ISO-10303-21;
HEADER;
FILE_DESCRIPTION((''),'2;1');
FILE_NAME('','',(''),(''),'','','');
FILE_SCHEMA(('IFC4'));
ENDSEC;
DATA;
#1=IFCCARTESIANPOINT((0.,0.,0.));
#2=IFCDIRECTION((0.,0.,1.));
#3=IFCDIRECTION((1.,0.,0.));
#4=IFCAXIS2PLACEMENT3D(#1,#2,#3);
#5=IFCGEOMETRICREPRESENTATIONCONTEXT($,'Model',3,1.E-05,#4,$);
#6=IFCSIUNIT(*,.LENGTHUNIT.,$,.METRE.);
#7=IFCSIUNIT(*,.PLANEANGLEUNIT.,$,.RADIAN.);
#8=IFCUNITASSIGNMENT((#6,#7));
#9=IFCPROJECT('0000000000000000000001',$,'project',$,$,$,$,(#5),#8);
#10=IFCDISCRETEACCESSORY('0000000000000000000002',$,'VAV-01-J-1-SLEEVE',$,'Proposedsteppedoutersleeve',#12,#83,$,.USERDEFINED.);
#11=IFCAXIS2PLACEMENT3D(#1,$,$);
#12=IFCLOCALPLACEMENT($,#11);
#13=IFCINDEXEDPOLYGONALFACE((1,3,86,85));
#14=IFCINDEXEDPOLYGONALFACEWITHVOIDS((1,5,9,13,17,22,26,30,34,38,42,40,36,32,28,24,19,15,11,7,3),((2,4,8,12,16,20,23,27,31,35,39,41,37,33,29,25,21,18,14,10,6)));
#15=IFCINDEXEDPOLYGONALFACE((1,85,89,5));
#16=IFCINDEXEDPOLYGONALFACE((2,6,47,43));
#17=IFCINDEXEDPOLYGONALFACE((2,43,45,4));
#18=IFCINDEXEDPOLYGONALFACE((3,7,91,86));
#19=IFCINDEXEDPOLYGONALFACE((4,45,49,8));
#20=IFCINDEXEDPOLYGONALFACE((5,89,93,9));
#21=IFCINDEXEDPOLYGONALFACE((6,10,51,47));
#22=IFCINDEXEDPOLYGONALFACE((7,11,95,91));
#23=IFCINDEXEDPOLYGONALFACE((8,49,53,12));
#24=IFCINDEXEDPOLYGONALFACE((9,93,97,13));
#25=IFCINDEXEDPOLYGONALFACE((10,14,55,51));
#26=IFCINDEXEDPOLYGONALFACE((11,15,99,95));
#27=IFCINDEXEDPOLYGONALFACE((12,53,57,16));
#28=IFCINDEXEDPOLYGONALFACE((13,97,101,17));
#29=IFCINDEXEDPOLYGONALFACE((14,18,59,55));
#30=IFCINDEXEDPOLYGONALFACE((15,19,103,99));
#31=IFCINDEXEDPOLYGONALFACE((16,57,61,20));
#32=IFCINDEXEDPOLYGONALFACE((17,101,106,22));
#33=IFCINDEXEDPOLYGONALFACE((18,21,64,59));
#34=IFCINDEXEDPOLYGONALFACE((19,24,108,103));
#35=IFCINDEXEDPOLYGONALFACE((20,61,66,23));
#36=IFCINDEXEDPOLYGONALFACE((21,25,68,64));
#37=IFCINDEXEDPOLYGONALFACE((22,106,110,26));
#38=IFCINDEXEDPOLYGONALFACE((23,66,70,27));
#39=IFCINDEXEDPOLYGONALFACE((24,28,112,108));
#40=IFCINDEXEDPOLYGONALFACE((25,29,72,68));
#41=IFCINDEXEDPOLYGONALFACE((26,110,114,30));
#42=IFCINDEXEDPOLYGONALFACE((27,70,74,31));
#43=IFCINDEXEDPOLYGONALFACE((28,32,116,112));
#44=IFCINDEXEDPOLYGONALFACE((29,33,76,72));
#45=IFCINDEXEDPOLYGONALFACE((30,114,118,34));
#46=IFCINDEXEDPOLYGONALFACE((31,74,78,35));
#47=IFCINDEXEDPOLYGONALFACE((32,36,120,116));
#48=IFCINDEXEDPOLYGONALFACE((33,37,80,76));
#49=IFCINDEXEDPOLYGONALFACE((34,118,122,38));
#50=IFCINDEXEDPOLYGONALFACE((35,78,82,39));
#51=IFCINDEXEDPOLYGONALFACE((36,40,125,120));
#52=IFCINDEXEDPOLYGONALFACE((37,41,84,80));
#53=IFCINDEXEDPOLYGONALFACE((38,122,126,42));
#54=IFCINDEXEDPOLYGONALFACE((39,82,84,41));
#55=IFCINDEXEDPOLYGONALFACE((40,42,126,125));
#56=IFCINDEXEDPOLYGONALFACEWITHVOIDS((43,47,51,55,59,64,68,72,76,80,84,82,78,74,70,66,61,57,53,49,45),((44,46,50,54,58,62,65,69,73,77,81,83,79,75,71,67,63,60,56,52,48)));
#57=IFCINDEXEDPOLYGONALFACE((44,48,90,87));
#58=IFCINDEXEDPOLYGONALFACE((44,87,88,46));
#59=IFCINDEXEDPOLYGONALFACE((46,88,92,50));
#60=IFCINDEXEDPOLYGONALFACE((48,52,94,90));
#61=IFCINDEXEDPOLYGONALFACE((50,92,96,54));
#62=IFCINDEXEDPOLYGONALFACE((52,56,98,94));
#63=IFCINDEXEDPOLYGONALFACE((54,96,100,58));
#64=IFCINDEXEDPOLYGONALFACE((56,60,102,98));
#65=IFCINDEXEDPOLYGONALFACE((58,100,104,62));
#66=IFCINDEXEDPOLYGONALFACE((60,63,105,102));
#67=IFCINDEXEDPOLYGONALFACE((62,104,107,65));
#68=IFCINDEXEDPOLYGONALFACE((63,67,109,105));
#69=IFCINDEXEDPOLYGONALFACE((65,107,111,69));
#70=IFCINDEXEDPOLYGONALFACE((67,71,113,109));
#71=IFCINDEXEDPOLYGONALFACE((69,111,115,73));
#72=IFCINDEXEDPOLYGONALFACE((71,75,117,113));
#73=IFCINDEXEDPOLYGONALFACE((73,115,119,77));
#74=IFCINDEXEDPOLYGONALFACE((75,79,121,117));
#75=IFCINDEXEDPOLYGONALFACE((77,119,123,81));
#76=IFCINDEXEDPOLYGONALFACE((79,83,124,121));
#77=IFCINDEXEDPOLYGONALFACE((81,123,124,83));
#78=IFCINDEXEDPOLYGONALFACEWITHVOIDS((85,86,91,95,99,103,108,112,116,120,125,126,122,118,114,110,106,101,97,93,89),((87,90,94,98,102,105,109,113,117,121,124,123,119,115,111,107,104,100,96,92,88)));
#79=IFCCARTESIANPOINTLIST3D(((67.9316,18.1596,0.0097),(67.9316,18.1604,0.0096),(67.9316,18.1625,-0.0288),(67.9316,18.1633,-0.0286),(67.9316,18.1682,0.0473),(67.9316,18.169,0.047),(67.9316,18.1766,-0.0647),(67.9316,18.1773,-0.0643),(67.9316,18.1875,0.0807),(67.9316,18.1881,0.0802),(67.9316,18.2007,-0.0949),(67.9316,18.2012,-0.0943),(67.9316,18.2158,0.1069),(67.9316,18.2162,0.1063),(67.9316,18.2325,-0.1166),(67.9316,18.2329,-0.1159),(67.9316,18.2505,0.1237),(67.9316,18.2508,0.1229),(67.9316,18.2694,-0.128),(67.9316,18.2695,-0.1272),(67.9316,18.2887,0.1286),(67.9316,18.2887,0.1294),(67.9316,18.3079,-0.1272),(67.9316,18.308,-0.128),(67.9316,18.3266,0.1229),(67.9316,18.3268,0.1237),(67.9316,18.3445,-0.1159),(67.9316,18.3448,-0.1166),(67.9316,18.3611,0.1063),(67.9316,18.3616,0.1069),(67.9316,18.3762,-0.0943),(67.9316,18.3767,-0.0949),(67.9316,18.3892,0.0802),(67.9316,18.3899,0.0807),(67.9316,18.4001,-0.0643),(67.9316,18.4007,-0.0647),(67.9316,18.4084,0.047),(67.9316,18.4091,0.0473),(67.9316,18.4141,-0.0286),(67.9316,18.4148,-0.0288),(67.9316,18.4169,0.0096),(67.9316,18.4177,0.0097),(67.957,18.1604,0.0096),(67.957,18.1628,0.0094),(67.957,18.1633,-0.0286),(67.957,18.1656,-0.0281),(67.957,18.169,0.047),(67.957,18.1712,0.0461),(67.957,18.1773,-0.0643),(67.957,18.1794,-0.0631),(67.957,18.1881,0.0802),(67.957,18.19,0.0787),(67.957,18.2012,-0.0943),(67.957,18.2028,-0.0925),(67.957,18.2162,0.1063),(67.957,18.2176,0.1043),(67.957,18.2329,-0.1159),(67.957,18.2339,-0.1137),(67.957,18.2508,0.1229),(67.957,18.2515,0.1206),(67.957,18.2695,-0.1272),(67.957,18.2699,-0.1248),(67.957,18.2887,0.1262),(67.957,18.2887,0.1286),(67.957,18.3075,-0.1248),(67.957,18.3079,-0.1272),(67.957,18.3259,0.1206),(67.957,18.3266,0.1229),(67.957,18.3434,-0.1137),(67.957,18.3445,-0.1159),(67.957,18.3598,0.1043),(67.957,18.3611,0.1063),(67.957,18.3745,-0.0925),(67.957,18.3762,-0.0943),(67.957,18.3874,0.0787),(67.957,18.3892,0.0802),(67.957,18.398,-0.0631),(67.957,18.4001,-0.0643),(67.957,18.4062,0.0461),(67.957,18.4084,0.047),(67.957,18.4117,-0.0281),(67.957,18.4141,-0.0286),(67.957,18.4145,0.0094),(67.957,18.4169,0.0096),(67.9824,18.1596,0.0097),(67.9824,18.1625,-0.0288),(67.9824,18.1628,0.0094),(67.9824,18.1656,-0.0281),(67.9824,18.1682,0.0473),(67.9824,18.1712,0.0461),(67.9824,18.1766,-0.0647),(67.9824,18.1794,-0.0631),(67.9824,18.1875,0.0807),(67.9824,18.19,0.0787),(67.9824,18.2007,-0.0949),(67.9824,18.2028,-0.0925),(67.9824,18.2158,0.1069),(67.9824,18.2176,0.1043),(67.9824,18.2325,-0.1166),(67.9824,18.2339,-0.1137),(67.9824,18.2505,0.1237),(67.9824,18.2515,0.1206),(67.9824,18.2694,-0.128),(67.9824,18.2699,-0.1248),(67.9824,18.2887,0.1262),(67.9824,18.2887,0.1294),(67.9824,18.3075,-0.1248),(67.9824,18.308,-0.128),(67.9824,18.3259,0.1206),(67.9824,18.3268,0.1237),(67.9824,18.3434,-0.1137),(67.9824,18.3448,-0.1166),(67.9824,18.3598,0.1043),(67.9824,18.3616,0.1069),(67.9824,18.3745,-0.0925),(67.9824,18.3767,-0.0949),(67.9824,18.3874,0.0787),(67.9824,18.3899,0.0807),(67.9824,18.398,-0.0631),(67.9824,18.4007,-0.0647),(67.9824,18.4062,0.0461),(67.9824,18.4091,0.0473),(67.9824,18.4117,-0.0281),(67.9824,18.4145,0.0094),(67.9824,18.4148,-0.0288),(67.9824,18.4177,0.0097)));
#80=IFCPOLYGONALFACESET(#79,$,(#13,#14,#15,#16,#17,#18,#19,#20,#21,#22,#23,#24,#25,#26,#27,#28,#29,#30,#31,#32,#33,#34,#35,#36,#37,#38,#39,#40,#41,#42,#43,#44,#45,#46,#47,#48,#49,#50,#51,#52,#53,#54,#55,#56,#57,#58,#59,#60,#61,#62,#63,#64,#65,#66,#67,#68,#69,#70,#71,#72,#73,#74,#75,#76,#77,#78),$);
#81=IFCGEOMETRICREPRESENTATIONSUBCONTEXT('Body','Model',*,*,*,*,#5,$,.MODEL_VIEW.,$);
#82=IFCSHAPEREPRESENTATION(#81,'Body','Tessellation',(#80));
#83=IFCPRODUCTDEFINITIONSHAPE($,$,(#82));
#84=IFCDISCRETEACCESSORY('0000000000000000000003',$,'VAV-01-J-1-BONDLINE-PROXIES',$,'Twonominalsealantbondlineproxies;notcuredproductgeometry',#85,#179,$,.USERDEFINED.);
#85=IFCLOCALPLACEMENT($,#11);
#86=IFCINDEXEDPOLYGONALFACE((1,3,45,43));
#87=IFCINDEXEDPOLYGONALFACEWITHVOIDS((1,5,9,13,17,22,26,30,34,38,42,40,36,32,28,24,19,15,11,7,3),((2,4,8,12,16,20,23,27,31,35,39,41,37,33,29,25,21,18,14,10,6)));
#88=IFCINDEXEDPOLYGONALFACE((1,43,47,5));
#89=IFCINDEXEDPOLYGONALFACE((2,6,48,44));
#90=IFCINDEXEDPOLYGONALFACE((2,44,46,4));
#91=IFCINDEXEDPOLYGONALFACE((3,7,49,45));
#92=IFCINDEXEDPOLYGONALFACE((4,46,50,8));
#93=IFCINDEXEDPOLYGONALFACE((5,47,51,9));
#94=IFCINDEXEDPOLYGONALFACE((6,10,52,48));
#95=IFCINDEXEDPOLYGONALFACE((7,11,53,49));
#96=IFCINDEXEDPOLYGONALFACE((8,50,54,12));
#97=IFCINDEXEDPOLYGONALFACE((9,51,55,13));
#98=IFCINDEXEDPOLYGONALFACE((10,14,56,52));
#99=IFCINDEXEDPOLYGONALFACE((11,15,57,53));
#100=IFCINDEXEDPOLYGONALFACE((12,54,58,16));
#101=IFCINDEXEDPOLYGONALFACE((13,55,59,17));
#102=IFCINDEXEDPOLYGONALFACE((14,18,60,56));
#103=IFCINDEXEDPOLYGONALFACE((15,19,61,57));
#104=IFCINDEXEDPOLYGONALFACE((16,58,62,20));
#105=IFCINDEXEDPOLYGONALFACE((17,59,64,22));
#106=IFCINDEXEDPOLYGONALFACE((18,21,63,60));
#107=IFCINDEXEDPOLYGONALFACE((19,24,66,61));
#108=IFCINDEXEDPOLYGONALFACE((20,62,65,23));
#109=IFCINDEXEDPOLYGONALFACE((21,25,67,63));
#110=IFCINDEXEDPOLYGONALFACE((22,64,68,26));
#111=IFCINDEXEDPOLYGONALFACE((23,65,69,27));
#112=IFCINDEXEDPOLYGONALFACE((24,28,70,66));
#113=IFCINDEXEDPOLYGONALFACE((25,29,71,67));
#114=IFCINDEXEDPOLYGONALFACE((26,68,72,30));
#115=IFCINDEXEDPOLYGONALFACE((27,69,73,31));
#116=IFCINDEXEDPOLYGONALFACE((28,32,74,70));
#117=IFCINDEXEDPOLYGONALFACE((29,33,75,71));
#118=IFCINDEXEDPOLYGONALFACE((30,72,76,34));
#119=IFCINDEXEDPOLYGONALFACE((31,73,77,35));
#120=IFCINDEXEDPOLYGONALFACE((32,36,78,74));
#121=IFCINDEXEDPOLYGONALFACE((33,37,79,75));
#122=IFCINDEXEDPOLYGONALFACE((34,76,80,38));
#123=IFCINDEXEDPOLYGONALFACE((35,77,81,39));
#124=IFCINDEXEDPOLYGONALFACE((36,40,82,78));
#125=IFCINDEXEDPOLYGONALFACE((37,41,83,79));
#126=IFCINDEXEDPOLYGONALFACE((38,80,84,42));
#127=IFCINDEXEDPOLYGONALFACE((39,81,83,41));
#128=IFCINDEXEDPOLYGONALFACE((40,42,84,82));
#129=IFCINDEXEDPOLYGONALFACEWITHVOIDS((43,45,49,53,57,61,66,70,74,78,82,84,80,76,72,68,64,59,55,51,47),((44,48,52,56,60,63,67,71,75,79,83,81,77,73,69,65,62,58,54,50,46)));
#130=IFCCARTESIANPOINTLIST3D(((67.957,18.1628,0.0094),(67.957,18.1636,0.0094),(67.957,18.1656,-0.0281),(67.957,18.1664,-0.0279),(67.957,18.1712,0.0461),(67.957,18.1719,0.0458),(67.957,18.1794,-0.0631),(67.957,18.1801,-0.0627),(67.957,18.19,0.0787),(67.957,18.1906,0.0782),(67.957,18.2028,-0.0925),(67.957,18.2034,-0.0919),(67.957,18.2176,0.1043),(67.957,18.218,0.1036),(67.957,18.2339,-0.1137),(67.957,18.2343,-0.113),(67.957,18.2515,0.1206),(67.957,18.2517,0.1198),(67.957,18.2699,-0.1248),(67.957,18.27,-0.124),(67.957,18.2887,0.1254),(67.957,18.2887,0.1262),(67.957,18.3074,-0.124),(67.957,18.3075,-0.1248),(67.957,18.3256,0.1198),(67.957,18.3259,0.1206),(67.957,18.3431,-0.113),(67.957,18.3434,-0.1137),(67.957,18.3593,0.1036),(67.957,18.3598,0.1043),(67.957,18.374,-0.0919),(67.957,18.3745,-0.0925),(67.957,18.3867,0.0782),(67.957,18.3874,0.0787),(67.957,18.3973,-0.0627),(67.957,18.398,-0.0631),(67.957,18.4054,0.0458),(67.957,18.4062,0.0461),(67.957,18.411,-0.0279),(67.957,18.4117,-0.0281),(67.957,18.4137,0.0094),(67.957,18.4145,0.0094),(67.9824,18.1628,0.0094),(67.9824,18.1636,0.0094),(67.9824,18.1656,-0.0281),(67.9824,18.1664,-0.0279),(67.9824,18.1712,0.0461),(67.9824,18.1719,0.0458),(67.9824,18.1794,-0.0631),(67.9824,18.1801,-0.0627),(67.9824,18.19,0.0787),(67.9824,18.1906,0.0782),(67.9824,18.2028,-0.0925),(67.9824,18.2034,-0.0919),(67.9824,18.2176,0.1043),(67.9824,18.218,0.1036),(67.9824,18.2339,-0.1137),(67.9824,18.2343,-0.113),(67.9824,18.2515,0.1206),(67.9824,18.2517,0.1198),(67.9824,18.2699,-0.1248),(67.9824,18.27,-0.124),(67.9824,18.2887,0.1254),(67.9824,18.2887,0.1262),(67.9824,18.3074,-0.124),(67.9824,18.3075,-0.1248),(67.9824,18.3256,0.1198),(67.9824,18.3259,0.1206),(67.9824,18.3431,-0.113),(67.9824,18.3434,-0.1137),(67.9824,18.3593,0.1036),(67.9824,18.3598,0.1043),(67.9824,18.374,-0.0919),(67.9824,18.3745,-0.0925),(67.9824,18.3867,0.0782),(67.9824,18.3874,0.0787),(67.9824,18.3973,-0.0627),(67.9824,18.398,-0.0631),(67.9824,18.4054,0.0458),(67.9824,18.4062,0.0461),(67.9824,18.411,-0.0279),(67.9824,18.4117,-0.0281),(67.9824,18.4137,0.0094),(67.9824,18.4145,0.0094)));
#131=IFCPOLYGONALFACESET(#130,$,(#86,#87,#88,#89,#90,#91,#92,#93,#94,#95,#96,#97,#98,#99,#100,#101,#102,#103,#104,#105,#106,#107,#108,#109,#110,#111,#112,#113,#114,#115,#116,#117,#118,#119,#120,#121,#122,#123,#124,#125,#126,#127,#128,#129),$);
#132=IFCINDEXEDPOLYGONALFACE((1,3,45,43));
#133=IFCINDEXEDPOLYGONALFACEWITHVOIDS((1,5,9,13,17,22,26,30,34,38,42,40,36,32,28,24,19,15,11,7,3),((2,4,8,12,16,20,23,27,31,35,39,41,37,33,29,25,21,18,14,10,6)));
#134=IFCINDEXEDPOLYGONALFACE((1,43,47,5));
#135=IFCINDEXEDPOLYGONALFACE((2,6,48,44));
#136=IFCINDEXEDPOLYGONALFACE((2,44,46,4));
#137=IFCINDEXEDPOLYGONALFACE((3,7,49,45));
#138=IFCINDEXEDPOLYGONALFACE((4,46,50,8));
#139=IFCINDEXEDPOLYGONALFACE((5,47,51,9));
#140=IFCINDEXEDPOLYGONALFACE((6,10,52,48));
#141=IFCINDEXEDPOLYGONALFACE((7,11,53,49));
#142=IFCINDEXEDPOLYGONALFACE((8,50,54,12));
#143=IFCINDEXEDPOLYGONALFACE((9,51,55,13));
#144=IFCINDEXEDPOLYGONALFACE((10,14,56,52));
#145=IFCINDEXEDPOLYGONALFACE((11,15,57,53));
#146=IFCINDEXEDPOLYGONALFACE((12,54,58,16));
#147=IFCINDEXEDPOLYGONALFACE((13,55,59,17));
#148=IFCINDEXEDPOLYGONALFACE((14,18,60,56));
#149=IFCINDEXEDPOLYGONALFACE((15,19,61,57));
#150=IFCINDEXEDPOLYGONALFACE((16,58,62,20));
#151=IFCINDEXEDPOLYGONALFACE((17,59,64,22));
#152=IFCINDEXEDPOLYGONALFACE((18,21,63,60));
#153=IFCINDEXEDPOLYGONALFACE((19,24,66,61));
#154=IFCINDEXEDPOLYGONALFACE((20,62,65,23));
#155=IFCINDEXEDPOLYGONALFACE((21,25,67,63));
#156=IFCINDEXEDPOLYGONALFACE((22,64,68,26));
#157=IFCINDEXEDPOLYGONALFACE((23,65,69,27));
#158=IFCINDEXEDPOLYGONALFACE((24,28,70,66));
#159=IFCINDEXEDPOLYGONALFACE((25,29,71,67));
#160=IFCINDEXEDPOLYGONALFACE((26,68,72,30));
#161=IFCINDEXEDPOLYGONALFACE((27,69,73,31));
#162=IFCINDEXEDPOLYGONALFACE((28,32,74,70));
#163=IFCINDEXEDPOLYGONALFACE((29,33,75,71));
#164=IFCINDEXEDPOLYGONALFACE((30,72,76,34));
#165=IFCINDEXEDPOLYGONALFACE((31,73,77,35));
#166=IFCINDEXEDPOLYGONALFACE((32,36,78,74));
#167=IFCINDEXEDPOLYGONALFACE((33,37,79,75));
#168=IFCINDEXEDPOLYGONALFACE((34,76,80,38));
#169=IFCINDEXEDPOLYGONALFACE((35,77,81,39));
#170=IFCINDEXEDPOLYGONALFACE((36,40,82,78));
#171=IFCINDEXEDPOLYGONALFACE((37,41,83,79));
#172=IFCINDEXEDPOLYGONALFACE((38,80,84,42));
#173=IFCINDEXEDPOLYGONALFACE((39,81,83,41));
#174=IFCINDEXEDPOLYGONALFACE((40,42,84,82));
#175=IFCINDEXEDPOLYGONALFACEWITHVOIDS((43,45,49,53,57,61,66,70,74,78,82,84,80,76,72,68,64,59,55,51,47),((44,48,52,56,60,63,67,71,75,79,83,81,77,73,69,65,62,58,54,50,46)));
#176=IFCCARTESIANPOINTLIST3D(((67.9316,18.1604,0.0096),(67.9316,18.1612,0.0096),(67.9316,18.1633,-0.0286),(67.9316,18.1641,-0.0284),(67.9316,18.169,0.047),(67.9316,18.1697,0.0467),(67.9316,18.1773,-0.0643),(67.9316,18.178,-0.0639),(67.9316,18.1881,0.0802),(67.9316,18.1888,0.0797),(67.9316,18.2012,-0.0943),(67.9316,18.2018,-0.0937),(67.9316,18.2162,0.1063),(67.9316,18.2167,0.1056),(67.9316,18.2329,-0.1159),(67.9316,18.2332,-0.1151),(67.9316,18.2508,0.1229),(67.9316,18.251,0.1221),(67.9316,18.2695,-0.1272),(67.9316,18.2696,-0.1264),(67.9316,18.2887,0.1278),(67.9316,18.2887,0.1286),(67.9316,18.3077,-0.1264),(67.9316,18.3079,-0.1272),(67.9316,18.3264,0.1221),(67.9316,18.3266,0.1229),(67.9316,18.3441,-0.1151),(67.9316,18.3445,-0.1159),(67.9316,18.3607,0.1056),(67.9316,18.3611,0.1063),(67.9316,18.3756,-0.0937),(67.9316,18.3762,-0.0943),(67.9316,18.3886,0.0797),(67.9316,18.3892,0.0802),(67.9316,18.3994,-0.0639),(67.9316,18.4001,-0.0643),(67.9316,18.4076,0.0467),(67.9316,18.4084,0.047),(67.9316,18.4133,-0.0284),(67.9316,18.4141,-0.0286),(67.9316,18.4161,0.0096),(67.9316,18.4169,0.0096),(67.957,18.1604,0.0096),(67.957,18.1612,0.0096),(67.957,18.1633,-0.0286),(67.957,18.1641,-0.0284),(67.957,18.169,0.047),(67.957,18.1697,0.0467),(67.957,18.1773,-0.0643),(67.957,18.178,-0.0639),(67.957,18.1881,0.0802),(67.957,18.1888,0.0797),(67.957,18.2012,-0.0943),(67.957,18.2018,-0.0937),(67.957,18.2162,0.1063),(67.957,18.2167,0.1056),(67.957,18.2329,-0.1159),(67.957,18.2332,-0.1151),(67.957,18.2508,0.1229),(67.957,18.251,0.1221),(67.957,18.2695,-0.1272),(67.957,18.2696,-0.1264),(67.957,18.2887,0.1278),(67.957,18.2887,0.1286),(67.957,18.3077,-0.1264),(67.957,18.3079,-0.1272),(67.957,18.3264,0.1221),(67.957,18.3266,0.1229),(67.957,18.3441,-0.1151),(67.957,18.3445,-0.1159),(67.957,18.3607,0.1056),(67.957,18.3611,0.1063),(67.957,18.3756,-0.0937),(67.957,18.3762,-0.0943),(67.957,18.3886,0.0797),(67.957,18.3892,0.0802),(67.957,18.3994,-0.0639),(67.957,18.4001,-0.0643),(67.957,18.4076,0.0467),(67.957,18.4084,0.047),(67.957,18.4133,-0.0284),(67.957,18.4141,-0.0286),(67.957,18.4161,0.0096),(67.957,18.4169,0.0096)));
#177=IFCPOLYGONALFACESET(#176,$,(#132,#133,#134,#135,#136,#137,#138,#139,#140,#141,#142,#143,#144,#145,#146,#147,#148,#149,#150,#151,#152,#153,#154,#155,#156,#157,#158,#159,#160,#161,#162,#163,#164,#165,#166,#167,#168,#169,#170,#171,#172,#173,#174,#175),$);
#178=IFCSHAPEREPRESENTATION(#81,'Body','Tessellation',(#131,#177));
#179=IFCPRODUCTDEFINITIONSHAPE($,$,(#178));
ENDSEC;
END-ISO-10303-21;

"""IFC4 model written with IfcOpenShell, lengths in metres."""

from ifc_helpers import new_model, entity, si_unit, frame, origin_with_axes, place, context, subcontext, project, element, save


model = new_model("IFC4")

# Units and contexts
model_context = context("Model", 3, precision=1e-05, world=origin_with_axes())
body_context = subcontext(model_context, "Body", "Model", "MODEL_VIEW")
ifc_project = project(units=[si_unit("LENGTHUNIT", "METRE"), si_unit("PLANEANGLEUNIT", "RADIAN")], contexts=[model_context])

# Discrete accessories
discrete_accessory_1_placement = place(None, frame((67.957, 18.2887, 0.0), z_axis=(0.0, -1.0, 0.0), x_axis=(0.0, 0.0, 1.0)))
element("IfcDiscreteAccessory", 1, at=discrete_accessory_1_placement, Name="VAV-01-J-1-SLEEVE", ObjectType="Proposedsteppedoutersleeve", PredefinedType="USERDEFINED", context=body_context, shape_type="SweptSolid", body=[
    entity("IfcRevolvedAreaSolid", entity("IfcArbitraryClosedProfileDef", "AREA", None, entity("IfcPolyline", [entity("IfcCartesianPoint", [0.1262, -0.0254]), entity("IfcCartesianPoint", [0.1294, -0.0254]), entity("IfcCartesianPoint", [0.1294, 0.0254]), entity("IfcCartesianPoint", [0.1286, 0.0254]), entity("IfcCartesianPoint", [0.1286, 0.0]), entity("IfcCartesianPoint", [0.1262, 0.0]), entity("IfcCartesianPoint", [0.1262, -0.0254])])), entity("IfcAxis2Placement3D", entity("IfcCartesianPoint", [0.0, 0.0, 0.0])), entity("IfcAxis1Placement", entity("IfcCartesianPoint", [0.0, 0.0, 0.0]), entity("IfcDirection", [0.0, 1.0, 0.0])), 6.283185),
])
discrete_accessory_2_placement = place(None, frame((67.957, 18.2887, 0.0), z_axis=(0.0, -1.0, 0.0), x_axis=(0.0, 0.0, 1.0)))
element("IfcDiscreteAccessory", 2, at=discrete_accessory_2_placement, Name="VAV-01-J-1-BONDLINE-PROXIES", ObjectType="Twonominalsealantbondlineproxies;notcuredproductgeometry", PredefinedType="USERDEFINED", context=body_context, shape_type="SweptSolid", body=[
    entity("IfcRevolvedAreaSolid", entity("IfcArbitraryClosedProfileDef", "AREA", None, entity("IfcPolyline", [entity("IfcCartesianPoint", [0.1254, -0.0254]), entity("IfcCartesianPoint", [0.1262, -0.0254]), entity("IfcCartesianPoint", [0.1262, 0.0]), entity("IfcCartesianPoint", [0.1254, 0.0]), entity("IfcCartesianPoint", [0.1254, -0.0254])])), entity("IfcAxis2Placement3D", entity("IfcCartesianPoint", [0.0, 0.0, 0.0])), entity("IfcAxis1Placement", entity("IfcCartesianPoint", [0.0, 0.0, 0.0]), entity("IfcDirection", [0.0, 1.0, 0.0])), 6.283185),
    entity("IfcRevolvedAreaSolid", entity("IfcArbitraryClosedProfileDef", "AREA", None, entity("IfcPolyline", [entity("IfcCartesianPoint", [0.1278, 0.0]), entity("IfcCartesianPoint", [0.1286, 0.0]), entity("IfcCartesianPoint", [0.1286, 0.0254]), entity("IfcCartesianPoint", [0.1278, 0.0254]), entity("IfcCartesianPoint", [0.1278, 0.0])])), entity("IfcAxis2Placement3D", entity("IfcCartesianPoint", [0.0, 0.0, 0.0])), entity("IfcAxis1Placement", entity("IfcCartesianPoint", [0.0, 0.0, 0.0]), entity("IfcDirection", [0.0, 1.0, 0.0])), 6.283185),
])

save(model, "model.ifc")
